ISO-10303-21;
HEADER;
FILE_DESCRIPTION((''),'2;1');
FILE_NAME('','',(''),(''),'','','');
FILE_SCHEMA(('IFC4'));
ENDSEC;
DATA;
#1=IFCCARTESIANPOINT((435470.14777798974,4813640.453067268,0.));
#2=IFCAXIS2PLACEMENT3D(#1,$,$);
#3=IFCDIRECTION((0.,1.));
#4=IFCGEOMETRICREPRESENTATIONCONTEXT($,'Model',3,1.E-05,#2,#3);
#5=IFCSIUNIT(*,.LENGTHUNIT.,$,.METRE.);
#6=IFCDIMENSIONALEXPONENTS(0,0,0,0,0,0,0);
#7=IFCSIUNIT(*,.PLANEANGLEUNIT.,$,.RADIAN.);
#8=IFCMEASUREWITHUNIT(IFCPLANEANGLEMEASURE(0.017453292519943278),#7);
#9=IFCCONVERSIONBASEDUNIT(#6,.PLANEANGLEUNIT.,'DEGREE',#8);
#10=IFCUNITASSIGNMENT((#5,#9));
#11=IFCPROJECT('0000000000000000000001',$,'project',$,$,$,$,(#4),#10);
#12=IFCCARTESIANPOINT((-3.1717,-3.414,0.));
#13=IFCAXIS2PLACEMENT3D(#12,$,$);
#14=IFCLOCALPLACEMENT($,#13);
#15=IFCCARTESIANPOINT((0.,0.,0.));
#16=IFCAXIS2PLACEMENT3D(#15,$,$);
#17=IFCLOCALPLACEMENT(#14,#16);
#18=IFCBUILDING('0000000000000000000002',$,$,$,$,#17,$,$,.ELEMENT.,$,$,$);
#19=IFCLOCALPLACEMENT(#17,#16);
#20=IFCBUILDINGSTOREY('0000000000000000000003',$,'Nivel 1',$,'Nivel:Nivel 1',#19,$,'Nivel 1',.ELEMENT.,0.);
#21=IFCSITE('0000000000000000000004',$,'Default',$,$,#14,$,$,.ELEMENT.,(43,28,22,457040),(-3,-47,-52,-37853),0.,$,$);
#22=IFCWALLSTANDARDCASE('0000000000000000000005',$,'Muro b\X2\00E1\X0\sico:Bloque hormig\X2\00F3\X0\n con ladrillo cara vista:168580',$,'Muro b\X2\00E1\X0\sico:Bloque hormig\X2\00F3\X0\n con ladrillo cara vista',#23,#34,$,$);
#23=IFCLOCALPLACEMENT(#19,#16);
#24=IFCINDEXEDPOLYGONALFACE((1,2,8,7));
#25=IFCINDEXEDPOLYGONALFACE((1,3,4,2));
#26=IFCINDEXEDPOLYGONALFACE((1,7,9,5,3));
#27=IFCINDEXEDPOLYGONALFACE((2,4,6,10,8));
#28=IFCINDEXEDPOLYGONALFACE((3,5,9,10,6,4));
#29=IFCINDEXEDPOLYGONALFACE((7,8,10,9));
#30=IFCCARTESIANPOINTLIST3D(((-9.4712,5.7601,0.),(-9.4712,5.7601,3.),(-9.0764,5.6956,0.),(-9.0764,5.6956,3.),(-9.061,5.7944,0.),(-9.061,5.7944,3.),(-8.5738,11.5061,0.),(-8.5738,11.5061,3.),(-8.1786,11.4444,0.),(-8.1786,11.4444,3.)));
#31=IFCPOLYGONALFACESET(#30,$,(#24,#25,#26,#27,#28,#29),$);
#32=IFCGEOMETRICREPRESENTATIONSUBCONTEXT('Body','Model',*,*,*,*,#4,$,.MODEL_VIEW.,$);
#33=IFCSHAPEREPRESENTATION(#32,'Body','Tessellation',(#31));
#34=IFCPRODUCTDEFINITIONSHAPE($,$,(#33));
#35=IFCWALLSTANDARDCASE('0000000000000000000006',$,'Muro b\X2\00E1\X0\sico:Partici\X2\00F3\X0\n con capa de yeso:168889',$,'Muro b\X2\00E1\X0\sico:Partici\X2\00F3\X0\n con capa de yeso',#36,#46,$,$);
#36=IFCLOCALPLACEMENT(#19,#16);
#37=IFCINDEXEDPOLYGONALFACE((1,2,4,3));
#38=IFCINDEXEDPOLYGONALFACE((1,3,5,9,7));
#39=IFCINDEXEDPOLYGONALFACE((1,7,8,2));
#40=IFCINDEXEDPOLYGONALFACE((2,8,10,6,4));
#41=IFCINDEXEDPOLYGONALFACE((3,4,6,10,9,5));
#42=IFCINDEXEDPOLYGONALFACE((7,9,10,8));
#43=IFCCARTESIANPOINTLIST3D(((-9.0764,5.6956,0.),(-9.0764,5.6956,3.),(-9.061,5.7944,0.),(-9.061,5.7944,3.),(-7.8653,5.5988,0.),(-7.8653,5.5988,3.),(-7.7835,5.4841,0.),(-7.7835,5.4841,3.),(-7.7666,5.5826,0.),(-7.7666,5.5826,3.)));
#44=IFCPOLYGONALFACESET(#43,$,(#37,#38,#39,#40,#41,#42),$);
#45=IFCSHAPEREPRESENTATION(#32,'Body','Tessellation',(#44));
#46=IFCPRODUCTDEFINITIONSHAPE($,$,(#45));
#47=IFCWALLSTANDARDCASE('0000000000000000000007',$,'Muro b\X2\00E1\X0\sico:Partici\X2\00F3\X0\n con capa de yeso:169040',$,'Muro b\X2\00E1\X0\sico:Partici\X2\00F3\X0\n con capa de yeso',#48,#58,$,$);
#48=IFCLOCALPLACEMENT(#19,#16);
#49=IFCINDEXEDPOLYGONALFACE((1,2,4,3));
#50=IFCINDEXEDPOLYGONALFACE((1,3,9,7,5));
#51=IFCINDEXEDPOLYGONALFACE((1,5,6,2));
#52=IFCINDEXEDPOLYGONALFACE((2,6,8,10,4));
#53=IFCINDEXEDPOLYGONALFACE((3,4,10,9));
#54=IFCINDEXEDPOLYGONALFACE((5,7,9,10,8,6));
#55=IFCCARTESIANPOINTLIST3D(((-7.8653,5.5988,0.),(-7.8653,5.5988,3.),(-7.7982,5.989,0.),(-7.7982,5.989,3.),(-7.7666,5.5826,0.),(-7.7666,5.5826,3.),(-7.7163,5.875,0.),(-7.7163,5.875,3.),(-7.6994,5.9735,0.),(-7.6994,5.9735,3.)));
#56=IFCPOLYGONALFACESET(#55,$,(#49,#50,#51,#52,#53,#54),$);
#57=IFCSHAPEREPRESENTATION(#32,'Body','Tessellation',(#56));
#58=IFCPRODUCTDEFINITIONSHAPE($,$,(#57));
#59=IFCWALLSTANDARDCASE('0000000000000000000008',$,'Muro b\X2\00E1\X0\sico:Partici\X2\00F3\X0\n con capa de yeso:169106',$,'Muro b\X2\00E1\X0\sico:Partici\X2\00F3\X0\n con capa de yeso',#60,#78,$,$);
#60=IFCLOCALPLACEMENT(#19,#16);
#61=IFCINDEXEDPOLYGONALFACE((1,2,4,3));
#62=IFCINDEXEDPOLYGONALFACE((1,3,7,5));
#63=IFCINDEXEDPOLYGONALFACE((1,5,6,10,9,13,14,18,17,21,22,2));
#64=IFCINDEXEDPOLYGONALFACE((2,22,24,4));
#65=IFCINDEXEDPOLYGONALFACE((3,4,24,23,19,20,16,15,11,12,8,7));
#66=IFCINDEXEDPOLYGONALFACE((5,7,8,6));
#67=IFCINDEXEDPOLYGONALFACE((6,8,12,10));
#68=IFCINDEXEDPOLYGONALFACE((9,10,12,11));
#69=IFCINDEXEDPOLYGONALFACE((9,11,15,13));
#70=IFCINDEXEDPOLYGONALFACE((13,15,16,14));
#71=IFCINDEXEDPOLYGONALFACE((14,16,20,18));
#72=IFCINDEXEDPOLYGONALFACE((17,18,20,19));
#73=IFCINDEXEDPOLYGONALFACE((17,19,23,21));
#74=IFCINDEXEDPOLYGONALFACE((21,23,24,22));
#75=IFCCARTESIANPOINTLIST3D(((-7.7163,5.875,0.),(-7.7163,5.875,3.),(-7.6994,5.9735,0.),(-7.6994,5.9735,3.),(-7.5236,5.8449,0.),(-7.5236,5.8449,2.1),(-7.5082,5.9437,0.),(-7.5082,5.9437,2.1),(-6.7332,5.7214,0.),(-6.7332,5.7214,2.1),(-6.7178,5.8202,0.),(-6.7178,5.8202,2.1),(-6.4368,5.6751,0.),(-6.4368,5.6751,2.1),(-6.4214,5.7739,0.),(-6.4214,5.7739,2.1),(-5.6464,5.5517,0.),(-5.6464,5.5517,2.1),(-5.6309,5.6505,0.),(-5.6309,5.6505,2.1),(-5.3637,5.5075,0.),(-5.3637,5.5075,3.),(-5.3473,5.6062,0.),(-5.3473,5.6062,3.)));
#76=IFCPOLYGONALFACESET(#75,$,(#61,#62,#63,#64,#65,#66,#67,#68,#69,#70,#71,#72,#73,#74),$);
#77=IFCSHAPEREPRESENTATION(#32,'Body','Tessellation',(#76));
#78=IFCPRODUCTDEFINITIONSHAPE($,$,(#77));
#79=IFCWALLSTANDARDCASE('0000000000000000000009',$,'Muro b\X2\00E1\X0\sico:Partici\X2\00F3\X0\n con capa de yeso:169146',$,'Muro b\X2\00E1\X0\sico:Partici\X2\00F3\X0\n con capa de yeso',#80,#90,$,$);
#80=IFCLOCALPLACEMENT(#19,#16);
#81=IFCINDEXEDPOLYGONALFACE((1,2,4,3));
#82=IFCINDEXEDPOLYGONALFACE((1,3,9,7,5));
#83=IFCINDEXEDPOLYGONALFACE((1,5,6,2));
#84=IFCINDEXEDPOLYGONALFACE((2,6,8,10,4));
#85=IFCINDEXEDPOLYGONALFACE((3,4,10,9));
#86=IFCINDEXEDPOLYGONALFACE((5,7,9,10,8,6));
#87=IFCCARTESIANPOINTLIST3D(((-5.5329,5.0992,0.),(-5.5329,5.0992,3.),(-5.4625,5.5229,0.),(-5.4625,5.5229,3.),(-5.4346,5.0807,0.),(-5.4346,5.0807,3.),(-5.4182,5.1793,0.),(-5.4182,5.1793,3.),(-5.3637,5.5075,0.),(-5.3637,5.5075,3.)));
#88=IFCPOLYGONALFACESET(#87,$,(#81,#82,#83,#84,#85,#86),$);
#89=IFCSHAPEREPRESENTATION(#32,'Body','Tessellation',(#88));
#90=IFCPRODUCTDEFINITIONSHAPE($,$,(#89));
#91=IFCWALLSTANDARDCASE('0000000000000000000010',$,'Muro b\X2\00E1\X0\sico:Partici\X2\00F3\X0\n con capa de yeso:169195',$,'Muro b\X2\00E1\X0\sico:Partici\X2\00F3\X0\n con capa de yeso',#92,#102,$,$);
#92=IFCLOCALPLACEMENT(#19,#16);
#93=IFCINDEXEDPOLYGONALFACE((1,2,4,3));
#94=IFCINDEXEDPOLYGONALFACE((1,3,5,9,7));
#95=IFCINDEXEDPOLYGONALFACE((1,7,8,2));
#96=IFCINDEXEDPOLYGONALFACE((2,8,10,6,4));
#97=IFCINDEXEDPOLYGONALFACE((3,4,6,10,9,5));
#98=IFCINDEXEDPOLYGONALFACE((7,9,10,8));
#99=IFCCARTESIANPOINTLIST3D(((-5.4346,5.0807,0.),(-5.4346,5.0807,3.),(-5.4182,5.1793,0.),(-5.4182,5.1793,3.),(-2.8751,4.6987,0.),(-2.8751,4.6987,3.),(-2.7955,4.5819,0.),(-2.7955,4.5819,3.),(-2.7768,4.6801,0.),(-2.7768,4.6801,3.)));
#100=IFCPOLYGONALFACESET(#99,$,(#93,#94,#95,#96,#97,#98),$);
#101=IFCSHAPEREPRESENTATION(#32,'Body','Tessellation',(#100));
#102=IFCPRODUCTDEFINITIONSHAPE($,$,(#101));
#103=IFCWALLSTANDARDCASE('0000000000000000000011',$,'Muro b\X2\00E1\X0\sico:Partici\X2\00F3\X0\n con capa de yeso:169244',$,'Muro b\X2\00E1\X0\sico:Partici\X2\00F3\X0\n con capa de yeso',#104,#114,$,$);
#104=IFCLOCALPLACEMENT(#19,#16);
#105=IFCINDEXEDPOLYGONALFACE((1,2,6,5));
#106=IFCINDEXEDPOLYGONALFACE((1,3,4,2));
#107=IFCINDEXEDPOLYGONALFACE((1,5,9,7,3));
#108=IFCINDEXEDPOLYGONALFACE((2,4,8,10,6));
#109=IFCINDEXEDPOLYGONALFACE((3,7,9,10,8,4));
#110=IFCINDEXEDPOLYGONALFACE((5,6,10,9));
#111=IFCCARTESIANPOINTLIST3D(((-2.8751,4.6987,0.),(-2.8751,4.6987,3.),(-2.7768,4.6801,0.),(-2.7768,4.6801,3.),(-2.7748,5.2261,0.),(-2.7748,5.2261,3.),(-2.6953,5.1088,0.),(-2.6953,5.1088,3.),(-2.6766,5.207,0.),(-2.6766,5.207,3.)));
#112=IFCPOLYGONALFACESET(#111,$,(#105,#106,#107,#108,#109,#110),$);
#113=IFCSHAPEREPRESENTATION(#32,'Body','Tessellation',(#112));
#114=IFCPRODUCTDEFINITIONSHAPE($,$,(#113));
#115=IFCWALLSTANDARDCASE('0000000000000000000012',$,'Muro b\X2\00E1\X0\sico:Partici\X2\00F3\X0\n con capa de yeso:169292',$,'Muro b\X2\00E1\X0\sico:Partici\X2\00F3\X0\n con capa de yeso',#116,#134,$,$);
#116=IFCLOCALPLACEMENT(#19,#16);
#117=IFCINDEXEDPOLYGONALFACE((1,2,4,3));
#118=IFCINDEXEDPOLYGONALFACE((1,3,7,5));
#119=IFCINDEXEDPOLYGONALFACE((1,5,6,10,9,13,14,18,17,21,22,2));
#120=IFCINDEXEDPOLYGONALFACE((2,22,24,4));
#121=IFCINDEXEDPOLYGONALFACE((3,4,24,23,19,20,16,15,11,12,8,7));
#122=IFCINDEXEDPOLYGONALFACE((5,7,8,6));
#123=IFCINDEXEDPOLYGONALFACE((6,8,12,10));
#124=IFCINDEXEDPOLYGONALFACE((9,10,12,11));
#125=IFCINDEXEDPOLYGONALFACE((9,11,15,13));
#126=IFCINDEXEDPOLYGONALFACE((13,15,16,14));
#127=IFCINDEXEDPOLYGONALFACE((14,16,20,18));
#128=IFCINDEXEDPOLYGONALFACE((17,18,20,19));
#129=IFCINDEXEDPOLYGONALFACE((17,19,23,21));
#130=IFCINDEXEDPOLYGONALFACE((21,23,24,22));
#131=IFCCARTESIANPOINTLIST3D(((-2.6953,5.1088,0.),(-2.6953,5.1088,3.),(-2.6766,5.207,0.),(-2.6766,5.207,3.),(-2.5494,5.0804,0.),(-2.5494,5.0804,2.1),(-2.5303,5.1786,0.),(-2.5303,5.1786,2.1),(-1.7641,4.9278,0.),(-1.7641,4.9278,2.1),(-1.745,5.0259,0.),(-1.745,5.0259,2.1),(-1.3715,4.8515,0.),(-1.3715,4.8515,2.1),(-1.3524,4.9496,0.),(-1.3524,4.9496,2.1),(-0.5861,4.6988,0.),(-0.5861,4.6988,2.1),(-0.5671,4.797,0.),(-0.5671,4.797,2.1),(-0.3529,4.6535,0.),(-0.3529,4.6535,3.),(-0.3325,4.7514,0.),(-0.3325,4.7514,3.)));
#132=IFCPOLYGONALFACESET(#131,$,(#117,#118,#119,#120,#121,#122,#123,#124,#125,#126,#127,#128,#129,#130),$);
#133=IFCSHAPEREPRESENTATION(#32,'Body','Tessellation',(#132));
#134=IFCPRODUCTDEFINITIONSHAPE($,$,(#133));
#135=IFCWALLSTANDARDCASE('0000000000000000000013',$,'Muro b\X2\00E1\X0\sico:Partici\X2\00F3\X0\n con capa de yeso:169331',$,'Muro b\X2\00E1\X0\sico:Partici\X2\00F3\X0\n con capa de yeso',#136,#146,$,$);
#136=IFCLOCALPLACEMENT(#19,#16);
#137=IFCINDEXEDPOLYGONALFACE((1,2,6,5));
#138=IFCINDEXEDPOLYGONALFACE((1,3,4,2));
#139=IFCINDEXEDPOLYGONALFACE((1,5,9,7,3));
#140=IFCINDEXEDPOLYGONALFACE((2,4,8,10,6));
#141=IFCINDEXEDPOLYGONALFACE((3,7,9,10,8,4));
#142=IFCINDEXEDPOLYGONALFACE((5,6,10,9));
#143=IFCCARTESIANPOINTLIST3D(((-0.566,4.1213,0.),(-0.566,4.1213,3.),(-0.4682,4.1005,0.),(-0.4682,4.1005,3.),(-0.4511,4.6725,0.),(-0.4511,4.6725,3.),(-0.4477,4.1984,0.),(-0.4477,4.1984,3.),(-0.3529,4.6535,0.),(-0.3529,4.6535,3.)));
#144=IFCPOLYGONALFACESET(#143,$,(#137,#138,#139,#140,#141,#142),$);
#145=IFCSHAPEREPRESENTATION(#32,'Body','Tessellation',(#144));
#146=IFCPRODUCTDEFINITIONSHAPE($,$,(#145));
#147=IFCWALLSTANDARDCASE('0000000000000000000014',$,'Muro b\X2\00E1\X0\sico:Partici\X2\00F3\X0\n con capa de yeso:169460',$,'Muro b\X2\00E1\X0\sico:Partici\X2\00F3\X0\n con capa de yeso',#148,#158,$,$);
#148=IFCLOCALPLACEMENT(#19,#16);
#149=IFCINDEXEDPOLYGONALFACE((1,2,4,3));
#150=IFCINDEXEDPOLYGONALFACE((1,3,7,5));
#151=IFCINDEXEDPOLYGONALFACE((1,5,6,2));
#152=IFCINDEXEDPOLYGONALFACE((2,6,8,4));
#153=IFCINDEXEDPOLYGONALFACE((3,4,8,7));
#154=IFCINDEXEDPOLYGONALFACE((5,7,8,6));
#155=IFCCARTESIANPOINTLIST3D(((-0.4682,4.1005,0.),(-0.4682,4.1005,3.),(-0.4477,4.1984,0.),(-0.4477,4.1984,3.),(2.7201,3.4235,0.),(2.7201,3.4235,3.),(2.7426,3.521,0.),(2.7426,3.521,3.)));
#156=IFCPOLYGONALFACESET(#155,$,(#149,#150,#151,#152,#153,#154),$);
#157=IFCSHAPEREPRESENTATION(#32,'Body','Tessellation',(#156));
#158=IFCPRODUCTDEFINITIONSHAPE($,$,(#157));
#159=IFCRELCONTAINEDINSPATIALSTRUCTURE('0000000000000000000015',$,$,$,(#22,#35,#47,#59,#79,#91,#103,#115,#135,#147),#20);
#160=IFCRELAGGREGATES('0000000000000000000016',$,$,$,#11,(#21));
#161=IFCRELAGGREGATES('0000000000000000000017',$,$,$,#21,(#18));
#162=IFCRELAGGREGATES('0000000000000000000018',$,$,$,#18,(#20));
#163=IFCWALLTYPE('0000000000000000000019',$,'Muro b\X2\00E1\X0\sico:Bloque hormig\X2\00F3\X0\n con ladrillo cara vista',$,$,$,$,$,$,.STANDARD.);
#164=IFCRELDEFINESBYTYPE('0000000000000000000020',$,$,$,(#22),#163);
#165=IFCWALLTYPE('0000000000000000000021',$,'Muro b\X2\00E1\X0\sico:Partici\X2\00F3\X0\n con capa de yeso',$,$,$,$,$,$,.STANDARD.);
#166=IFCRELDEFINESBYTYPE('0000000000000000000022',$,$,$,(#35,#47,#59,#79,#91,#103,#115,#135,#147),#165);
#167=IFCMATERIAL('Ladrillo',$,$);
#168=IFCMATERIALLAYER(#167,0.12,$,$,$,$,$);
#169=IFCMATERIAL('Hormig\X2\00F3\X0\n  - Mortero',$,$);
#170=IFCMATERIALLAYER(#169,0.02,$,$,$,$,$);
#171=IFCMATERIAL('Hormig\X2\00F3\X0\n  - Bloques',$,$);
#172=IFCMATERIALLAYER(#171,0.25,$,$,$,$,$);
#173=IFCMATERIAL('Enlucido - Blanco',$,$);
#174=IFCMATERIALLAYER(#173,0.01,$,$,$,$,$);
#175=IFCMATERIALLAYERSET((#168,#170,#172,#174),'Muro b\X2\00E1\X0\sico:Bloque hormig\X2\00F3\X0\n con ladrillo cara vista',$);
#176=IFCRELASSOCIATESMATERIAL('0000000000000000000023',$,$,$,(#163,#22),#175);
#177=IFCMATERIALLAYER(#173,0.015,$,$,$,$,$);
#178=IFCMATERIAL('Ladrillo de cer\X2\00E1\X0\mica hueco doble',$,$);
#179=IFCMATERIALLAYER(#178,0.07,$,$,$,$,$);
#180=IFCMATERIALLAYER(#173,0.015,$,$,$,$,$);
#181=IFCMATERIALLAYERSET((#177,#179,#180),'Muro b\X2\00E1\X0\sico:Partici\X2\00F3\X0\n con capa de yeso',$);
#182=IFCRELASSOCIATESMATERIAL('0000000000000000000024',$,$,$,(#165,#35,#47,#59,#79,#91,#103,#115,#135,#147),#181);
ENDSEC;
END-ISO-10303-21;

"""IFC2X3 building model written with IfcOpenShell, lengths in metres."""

from ifc_helpers import new_model, entity, si_unit, converted_unit, direction, frame, frame_2d, origin, place, context, subcontext, project, spatial, polyline, rectangle, outline, extrude, material, layer, layer_set, layer_usage, type_object, element, save


model = new_model("IFC2X3")

# Units and contexts
model_context = context("Model", 3, precision=1e-05, world=frame((435470.14777798974, 4813640.453067268, 0.0)), true_north=direction((0.0, 1.0)))
body_context = subcontext(model_context, "Body", "Model", "MODEL_VIEW")
ifc_project = project(units=[si_unit("LENGTHUNIT", "METRE"), converted_unit("PLANEANGLEUNIT", "DEGREE", entity("IfcPlaneAngleMeasure", 0.017453292519943278), si_unit("PLANEANGLEUNIT", "RADIAN"), dimensions=[0, 0, 0, 0, 0, 0, 0])], contexts=[model_context])

# Site, building, storey
site_placement = place(None, frame((-3.1717, -3.414, 0.0)))
site = spatial("IfcSite", under=ifc_project, at=site_placement, Name="Default", CompositionType="ELEMENT", RefLatitude=(43, 28, 22, 457040), RefLongitude=(-3, -47, -52, -37853), RefElevation=0.0)
building_placement = place(site_placement, origin())
building = spatial("IfcBuilding", under=site, at=building_placement, CompositionType="ELEMENT")
storey_placement = place(building_placement, origin())
storey = spatial("IfcBuildingStorey", under=building, at=storey_placement, Name="Nivel 1", ObjectType="Nivel:Nivel 1", LongName="Nivel 1", CompositionType="ELEMENT", Elevation=0.0)

# Walls
ifc_material_1 = material(Name="Ladrillo")
ifc_layer_1 = layer(ifc_material_1, 0.12)
ifc_material_2 = material(Name="Hormigón  - Mortero")
ifc_layer_2 = layer(ifc_material_2, 0.02)
ifc_material_3 = material(Name="Hormigón  - Bloques")
ifc_layer_3 = layer(ifc_material_3, 0.25)
ifc_material_4 = material(Name="Enlucido - Blanco")
ifc_layer_4 = layer(ifc_material_4, 0.01)
ifc_layer_set_1 = layer_set([ifc_layer_1, ifc_layer_2, ifc_layer_3, ifc_layer_4], Name="Muro básico:Bloque hormigón con ladrillo cara vista")
wall_type_1 = type_object("IfcWallType", Name="Muro básico:Bloque hormigón con ladrillo cara vista", PredefinedType="STANDARD", material=ifc_layer_set_1)
ifc_layer_usage_1 = layer_usage(ifc_layer_set_1, "AXIS2", "POSITIVE", -0.2)
wall_1_placement = place(storey_placement, frame((-8.3762, 11.4752, 0.0), z_axis=(0.0, 0.0, 1.0), x_axis=(-0.154315, -0.988022, 0.0)))
element("IfcWallStandardCase", 1, at=wall_1_placement, inside=storey, type_object=wall_type_1, material=ifc_layer_usage_1, Name="Muro básico:Bloque hormigón con ladrillo cara vista:168580", ObjectType="Muro básico:Bloque hormigón con ladrillo cara vista", context=body_context, shape_type="SweptSolid", body=[
    extrude(outline(polyline([(5.8156, -0.2), (5.8185, 0.2), (5.7185, 0.2), (0.0, 0.2), (0.0, -0.2), (5.8156, -0.2)])), origin(), (0.0, 0.0, 1.0), 3.0),
])
ifc_layer_5 = layer(ifc_material_4, 0.015)
ifc_material_5 = material(Name="Ladrillo de cerámica hueco doble")
ifc_layer_6 = layer(ifc_material_5, 0.07)
ifc_layer_7 = layer(ifc_material_4, 0.015)
ifc_layer_set_2 = layer_set([ifc_layer_5, ifc_layer_6, ifc_layer_7], Name="Muro básico:Partición con capa de yeso")
ifc_layer_usage_2 = layer_usage(ifc_layer_set_2, "AXIS2", "POSITIVE", -0.05)
wall_type_2 = type_object("IfcWallType", Name="Muro básico:Partición con capa de yeso", PredefinedType="STANDARD", material=ifc_layer_set_2)
wall_2_placement = place(storey_placement, frame((-9.0691, 5.745, 0.0), z_axis=(0.0, 0.0, 1.0), x_axis=(0.986886, -0.161421, 0.0)))
element("IfcWallStandardCase", 2, at=wall_2_placement, inside=storey, type_object=wall_type_2, material=ifc_layer_usage_2, Name="Muro básico:Partición con capa de yeso:168889", ObjectType="Muro básico:Partición con capa de yeso", context=body_context, shape_type="SweptSolid", body=[
    extrude(outline(polyline([(1.3108, -0.05), (1.3116, 0.05), (1.2116, 0.05), (0.0, 0.05), (0.0007, -0.05), (1.3108, -0.05)])), origin(), (0.0, 0.0, 1.0), 3.0),
])
ifc_layer_usage_3 = layer_usage(ifc_layer_set_2, "AXIS2", "POSITIVE", -0.05)
wall_3_placement = place(storey_placement, frame((-7.816, 5.5903, 0.0), z_axis=(0.0, 0.0, 1.0), x_axis=(0.169385, 0.98555, 0.0)))
element("IfcWallStandardCase", 3, at=wall_3_placement, inside=storey, type_object=wall_type_2, material=ifc_layer_usage_3, Name="Muro básico:Partición con capa de yeso:169040", ObjectType="Muro básico:Partición con capa de yeso", context=body_context, shape_type="SweptSolid", body=[
    extrude(outline(polyline([(0.3974, -0.05), (0.3959, 0.05), (0.0, 0.05), (0.0008, -0.05), (0.2974, -0.05), (0.3974, -0.05)])), origin(), (0.0, 0.0, 1.0), 3.0),
])

# Wall, openings
ifc_layer_usage_4 = layer_usage(ifc_layer_set_2, "AXIS2", "POSITIVE", -0.05)
wall_4_placement = place(storey_placement, frame((-7.7086, 5.9244, 0.0), z_axis=(0.0, 0.0, 1.0), x_axis=(0.988022, -0.154315, 0.0)))
wall_4 = element("IfcWallStandardCase", 4, at=wall_4_placement, inside=storey, type_object=wall_type_2, material=ifc_layer_usage_4, Name="Muro básico:Partición con capa de yeso:169106", ObjectType="Muro básico:Partición con capa de yeso", context=body_context, shape_type="SweptSolid", body=[
    extrude(outline(polyline([(0.0, -0.05), (2.2812, -0.05), (2.3812, -0.05), (2.3822, 0.05), (0.0015, 0.05), (0.0, -0.05)])), origin(), (0.0, 0.0, 1.0), 3.0),
])
opening_1_placement = place(wall_4_placement, frame((0.1951, -0.05, 0.0)))
element("IfcOpeningElement", 5, at=opening_1_placement, cuts=wall_4, ObjectType="Opening", context=body_context, shape_type="SweptSolid", body=[
    extrude(rectangle(XDim=2.1, YDim=0.8, at=frame_2d((1.05, 0.4), x_axis=(1.0, 0.0))), frame((0.0, 0.0, 0.0), z_axis=(0.0, 1.0, 0.0), x_axis=(0.0, 0.0, 1.0)), (0.0, 0.0, 1.0), 0.1),
])
opening_2_placement = place(wall_4_placement, frame((1.2951, -0.05, 0.0)))
element("IfcOpeningElement", 6, at=opening_2_placement, cuts=wall_4, ObjectType="Opening", context=body_context, shape_type="SweptSolid", body=[
    extrude(rectangle(XDim=2.1, YDim=0.8, at=frame_2d((1.05, 0.4), x_axis=(1.0, 0.0))), frame((0.0, 0.0, 0.0), z_axis=(0.0, 1.0, 0.0), x_axis=(0.0, 0.0, 1.0)), (0.0, 0.0, 1.0), 0.1),
])

# Walls
ifc_layer_usage_5 = layer_usage(ifc_layer_set_2, "AXIS2", "POSITIVE", -0.05)
wall_5_placement = place(storey_placement, frame((-5.413, 5.5157, 0.0), z_axis=(0.0, 0.0, 1.0), x_axis=(-0.16397, -0.986465, 0.0)))
element("IfcWallStandardCase", 7, at=wall_5_placement, inside=storey, type_object=wall_type_2, material=ifc_layer_usage_5, Name="Muro básico:Partición con capa de yeso:169146", ObjectType="Muro básico:Partición con capa de yeso", context=body_context, shape_type="SweptSolid", body=[
    extrude(outline(polyline([(0.4305, -0.05), (0.4327, 0.05), (0.3327, 0.05), (0.0, 0.05), (0.001, -0.05), (0.4305, -0.05)])), origin(), (0.0, 0.0, 1.0), 3.0),
])
ifc_layer_usage_6 = layer_usage(ifc_layer_set_2, "AXIS2", "POSITIVE", -0.05)
wall_6_placement = place(storey_placement, frame((-5.4275, 5.1302, 0.0), z_axis=(0.0, 0.0, 1.0), x_axis=(0.982607, -0.185698, 0.0)))
element("IfcWallStandardCase", 8, at=wall_6_placement, inside=storey, type_object=wall_type_2, material=ifc_layer_usage_6, Name="Muro básico:Partición con capa de yeso:169195", ObjectType="Muro básico:Partición con capa de yeso", context=body_context, shape_type="SweptSolid", body=[
    extrude(outline(polyline([(2.688, -0.05), (2.6881, 0.05), (2.5881, 0.05), (0.0, 0.05), (0.0022, -0.05), (2.688, -0.05)])), origin(), (0.0, 0.0, 1.0), 3.0),
])
ifc_layer_usage_7 = layer_usage(ifc_layer_set_2, "AXIS2", "POSITIVE", -0.05)
wall_7_placement = place(storey_placement, frame((-2.826, 4.6894, 0.0), z_axis=(0.0, 0.0, 1.0), x_axis=(0.18685, 0.982388, 0.0)))
element("IfcWallStandardCase", 9, at=wall_7_placement, inside=storey, type_object=wall_type_2, material=ifc_layer_usage_7, Name="Muro básico:Partición con capa de yeso:169244", ObjectType="Muro básico:Partición con capa de yeso", context=body_context, shape_type="SweptSolid", body=[
    extrude(outline(polyline([(0.5364, -0.05), (0.5368, 0.05), (0.0, 0.05), (0.0001, -0.05), (0.4364, -0.05), (0.5364, -0.05)])), origin(), (0.0, 0.0, 1.0), 3.0),
])

# Wall, openings
ifc_layer_usage_8 = layer_usage(ifc_layer_set_2, "AXIS2", "POSITIVE", -0.05)
wall_8_placement = place(storey_placement, frame((-2.6862, 5.1579, 0.0), z_axis=(0.0, 0.0, 1.0), x_axis=(0.981627, -0.190809, 0.0)))
wall_8 = element("IfcWallStandardCase", 10, at=wall_8_placement, inside=storey, type_object=wall_type_2, material=ifc_layer_usage_8, Name="Muro básico:Partición con capa de yeso:169292", ObjectType="Muro básico:Partición con capa de yeso", context=body_context, shape_type="SweptSolid", body=[
    extrude(outline(polyline([(0.0004, -0.05), (2.2867, -0.05), (2.3867, -0.05), (2.388, 0.05), (0.0, 0.05), (0.0004, -0.05)])), origin(), (0.0, 0.0, 1.0), 3.0),
])
opening_3_placement = place(wall_8_placement, frame((1.349, -0.05, 0.0)))
element("IfcOpeningElement", 11, at=opening_3_placement, cuts=wall_8, ObjectType="Opening", context=body_context, shape_type="SweptSolid", body=[
    extrude(rectangle(XDim=2.1, YDim=0.8, at=frame_2d((1.05, 0.4), x_axis=(1.0, 0.0))), frame((0.0, 0.0, 0.0), z_axis=(0.0, 1.0, 0.0), x_axis=(0.0, 0.0, 1.0)), (0.0, 0.0, 1.0), 0.1),
])
opening_4_placement = place(wall_8_placement, frame((0.149, -0.05, 0.0)))
element("IfcOpeningElement", 12, at=opening_4_placement, cuts=wall_8, ObjectType="Opening", context=body_context, shape_type="SweptSolid", body=[
    extrude(rectangle(XDim=2.1, YDim=0.8, at=frame_2d((1.05, 0.4), x_axis=(1.0, 0.0))), frame((0.0, 0.0, 0.0), z_axis=(0.0, 1.0, 0.0), x_axis=(0.0, 0.0, 1.0)), (0.0, 0.0, 1.0), 0.1),
])

# Walls
ifc_layer_usage_9 = layer_usage(ifc_layer_set_2, "AXIS2", "NEGATIVE", 0.05)
wall_9_placement = place(storey_placement, frame((-0.4018, 4.6637, 0.0), z_axis=(0.0, 0.0, 1.0), x_axis=(-0.204054, -0.97896, 0.0)))
element("IfcWallStandardCase", 13, at=wall_9_placement, inside=storey, type_object=wall_type_2, material=ifc_layer_usage_9, Name="Muro básico:Partición con capa de yeso:169331", ObjectType="Muro básico:Partición con capa de yeso", context=body_context, shape_type="SweptSolid", body=[
    extrude(outline(polyline([(0.5645, -0.05), (0.5648, 0.05), (0.4648, 0.05), (0.0, 0.05), (0.0014, -0.05), (0.5645, -0.05)])), origin(), (0.0, 0.0, 1.0), 3.0),
])
ifc_layer_usage_10 = layer_usage(ifc_layer_set_2, "AXIS2", "NEGATIVE", 0.05)
wall_10_placement = place(storey_placement, frame((-0.4581, 4.1495, 0.0), z_axis=(0.0, 0.0, 1.0), x_axis=(0.978192, -0.207703, 0.0)))
element("IfcWallStandardCase", 14, at=wall_10_placement, inside=storey, type_object=wall_type_2, material=ifc_layer_usage_10, Name="Muro básico:Partición con capa de yeso:169460", ObjectType="Muro básico:Partición con capa de yeso", context=body_context, shape_type="SweptSolid", body=[
    extrude(outline(polyline([(3.2597, -0.05), (3.2615, 0.05), (0.0, 0.05), (0.0004, -0.05), (3.2597, -0.05)])), origin(), (0.0, 0.0, 1.0), 3.0),
])

save(model, "model.ifc")
